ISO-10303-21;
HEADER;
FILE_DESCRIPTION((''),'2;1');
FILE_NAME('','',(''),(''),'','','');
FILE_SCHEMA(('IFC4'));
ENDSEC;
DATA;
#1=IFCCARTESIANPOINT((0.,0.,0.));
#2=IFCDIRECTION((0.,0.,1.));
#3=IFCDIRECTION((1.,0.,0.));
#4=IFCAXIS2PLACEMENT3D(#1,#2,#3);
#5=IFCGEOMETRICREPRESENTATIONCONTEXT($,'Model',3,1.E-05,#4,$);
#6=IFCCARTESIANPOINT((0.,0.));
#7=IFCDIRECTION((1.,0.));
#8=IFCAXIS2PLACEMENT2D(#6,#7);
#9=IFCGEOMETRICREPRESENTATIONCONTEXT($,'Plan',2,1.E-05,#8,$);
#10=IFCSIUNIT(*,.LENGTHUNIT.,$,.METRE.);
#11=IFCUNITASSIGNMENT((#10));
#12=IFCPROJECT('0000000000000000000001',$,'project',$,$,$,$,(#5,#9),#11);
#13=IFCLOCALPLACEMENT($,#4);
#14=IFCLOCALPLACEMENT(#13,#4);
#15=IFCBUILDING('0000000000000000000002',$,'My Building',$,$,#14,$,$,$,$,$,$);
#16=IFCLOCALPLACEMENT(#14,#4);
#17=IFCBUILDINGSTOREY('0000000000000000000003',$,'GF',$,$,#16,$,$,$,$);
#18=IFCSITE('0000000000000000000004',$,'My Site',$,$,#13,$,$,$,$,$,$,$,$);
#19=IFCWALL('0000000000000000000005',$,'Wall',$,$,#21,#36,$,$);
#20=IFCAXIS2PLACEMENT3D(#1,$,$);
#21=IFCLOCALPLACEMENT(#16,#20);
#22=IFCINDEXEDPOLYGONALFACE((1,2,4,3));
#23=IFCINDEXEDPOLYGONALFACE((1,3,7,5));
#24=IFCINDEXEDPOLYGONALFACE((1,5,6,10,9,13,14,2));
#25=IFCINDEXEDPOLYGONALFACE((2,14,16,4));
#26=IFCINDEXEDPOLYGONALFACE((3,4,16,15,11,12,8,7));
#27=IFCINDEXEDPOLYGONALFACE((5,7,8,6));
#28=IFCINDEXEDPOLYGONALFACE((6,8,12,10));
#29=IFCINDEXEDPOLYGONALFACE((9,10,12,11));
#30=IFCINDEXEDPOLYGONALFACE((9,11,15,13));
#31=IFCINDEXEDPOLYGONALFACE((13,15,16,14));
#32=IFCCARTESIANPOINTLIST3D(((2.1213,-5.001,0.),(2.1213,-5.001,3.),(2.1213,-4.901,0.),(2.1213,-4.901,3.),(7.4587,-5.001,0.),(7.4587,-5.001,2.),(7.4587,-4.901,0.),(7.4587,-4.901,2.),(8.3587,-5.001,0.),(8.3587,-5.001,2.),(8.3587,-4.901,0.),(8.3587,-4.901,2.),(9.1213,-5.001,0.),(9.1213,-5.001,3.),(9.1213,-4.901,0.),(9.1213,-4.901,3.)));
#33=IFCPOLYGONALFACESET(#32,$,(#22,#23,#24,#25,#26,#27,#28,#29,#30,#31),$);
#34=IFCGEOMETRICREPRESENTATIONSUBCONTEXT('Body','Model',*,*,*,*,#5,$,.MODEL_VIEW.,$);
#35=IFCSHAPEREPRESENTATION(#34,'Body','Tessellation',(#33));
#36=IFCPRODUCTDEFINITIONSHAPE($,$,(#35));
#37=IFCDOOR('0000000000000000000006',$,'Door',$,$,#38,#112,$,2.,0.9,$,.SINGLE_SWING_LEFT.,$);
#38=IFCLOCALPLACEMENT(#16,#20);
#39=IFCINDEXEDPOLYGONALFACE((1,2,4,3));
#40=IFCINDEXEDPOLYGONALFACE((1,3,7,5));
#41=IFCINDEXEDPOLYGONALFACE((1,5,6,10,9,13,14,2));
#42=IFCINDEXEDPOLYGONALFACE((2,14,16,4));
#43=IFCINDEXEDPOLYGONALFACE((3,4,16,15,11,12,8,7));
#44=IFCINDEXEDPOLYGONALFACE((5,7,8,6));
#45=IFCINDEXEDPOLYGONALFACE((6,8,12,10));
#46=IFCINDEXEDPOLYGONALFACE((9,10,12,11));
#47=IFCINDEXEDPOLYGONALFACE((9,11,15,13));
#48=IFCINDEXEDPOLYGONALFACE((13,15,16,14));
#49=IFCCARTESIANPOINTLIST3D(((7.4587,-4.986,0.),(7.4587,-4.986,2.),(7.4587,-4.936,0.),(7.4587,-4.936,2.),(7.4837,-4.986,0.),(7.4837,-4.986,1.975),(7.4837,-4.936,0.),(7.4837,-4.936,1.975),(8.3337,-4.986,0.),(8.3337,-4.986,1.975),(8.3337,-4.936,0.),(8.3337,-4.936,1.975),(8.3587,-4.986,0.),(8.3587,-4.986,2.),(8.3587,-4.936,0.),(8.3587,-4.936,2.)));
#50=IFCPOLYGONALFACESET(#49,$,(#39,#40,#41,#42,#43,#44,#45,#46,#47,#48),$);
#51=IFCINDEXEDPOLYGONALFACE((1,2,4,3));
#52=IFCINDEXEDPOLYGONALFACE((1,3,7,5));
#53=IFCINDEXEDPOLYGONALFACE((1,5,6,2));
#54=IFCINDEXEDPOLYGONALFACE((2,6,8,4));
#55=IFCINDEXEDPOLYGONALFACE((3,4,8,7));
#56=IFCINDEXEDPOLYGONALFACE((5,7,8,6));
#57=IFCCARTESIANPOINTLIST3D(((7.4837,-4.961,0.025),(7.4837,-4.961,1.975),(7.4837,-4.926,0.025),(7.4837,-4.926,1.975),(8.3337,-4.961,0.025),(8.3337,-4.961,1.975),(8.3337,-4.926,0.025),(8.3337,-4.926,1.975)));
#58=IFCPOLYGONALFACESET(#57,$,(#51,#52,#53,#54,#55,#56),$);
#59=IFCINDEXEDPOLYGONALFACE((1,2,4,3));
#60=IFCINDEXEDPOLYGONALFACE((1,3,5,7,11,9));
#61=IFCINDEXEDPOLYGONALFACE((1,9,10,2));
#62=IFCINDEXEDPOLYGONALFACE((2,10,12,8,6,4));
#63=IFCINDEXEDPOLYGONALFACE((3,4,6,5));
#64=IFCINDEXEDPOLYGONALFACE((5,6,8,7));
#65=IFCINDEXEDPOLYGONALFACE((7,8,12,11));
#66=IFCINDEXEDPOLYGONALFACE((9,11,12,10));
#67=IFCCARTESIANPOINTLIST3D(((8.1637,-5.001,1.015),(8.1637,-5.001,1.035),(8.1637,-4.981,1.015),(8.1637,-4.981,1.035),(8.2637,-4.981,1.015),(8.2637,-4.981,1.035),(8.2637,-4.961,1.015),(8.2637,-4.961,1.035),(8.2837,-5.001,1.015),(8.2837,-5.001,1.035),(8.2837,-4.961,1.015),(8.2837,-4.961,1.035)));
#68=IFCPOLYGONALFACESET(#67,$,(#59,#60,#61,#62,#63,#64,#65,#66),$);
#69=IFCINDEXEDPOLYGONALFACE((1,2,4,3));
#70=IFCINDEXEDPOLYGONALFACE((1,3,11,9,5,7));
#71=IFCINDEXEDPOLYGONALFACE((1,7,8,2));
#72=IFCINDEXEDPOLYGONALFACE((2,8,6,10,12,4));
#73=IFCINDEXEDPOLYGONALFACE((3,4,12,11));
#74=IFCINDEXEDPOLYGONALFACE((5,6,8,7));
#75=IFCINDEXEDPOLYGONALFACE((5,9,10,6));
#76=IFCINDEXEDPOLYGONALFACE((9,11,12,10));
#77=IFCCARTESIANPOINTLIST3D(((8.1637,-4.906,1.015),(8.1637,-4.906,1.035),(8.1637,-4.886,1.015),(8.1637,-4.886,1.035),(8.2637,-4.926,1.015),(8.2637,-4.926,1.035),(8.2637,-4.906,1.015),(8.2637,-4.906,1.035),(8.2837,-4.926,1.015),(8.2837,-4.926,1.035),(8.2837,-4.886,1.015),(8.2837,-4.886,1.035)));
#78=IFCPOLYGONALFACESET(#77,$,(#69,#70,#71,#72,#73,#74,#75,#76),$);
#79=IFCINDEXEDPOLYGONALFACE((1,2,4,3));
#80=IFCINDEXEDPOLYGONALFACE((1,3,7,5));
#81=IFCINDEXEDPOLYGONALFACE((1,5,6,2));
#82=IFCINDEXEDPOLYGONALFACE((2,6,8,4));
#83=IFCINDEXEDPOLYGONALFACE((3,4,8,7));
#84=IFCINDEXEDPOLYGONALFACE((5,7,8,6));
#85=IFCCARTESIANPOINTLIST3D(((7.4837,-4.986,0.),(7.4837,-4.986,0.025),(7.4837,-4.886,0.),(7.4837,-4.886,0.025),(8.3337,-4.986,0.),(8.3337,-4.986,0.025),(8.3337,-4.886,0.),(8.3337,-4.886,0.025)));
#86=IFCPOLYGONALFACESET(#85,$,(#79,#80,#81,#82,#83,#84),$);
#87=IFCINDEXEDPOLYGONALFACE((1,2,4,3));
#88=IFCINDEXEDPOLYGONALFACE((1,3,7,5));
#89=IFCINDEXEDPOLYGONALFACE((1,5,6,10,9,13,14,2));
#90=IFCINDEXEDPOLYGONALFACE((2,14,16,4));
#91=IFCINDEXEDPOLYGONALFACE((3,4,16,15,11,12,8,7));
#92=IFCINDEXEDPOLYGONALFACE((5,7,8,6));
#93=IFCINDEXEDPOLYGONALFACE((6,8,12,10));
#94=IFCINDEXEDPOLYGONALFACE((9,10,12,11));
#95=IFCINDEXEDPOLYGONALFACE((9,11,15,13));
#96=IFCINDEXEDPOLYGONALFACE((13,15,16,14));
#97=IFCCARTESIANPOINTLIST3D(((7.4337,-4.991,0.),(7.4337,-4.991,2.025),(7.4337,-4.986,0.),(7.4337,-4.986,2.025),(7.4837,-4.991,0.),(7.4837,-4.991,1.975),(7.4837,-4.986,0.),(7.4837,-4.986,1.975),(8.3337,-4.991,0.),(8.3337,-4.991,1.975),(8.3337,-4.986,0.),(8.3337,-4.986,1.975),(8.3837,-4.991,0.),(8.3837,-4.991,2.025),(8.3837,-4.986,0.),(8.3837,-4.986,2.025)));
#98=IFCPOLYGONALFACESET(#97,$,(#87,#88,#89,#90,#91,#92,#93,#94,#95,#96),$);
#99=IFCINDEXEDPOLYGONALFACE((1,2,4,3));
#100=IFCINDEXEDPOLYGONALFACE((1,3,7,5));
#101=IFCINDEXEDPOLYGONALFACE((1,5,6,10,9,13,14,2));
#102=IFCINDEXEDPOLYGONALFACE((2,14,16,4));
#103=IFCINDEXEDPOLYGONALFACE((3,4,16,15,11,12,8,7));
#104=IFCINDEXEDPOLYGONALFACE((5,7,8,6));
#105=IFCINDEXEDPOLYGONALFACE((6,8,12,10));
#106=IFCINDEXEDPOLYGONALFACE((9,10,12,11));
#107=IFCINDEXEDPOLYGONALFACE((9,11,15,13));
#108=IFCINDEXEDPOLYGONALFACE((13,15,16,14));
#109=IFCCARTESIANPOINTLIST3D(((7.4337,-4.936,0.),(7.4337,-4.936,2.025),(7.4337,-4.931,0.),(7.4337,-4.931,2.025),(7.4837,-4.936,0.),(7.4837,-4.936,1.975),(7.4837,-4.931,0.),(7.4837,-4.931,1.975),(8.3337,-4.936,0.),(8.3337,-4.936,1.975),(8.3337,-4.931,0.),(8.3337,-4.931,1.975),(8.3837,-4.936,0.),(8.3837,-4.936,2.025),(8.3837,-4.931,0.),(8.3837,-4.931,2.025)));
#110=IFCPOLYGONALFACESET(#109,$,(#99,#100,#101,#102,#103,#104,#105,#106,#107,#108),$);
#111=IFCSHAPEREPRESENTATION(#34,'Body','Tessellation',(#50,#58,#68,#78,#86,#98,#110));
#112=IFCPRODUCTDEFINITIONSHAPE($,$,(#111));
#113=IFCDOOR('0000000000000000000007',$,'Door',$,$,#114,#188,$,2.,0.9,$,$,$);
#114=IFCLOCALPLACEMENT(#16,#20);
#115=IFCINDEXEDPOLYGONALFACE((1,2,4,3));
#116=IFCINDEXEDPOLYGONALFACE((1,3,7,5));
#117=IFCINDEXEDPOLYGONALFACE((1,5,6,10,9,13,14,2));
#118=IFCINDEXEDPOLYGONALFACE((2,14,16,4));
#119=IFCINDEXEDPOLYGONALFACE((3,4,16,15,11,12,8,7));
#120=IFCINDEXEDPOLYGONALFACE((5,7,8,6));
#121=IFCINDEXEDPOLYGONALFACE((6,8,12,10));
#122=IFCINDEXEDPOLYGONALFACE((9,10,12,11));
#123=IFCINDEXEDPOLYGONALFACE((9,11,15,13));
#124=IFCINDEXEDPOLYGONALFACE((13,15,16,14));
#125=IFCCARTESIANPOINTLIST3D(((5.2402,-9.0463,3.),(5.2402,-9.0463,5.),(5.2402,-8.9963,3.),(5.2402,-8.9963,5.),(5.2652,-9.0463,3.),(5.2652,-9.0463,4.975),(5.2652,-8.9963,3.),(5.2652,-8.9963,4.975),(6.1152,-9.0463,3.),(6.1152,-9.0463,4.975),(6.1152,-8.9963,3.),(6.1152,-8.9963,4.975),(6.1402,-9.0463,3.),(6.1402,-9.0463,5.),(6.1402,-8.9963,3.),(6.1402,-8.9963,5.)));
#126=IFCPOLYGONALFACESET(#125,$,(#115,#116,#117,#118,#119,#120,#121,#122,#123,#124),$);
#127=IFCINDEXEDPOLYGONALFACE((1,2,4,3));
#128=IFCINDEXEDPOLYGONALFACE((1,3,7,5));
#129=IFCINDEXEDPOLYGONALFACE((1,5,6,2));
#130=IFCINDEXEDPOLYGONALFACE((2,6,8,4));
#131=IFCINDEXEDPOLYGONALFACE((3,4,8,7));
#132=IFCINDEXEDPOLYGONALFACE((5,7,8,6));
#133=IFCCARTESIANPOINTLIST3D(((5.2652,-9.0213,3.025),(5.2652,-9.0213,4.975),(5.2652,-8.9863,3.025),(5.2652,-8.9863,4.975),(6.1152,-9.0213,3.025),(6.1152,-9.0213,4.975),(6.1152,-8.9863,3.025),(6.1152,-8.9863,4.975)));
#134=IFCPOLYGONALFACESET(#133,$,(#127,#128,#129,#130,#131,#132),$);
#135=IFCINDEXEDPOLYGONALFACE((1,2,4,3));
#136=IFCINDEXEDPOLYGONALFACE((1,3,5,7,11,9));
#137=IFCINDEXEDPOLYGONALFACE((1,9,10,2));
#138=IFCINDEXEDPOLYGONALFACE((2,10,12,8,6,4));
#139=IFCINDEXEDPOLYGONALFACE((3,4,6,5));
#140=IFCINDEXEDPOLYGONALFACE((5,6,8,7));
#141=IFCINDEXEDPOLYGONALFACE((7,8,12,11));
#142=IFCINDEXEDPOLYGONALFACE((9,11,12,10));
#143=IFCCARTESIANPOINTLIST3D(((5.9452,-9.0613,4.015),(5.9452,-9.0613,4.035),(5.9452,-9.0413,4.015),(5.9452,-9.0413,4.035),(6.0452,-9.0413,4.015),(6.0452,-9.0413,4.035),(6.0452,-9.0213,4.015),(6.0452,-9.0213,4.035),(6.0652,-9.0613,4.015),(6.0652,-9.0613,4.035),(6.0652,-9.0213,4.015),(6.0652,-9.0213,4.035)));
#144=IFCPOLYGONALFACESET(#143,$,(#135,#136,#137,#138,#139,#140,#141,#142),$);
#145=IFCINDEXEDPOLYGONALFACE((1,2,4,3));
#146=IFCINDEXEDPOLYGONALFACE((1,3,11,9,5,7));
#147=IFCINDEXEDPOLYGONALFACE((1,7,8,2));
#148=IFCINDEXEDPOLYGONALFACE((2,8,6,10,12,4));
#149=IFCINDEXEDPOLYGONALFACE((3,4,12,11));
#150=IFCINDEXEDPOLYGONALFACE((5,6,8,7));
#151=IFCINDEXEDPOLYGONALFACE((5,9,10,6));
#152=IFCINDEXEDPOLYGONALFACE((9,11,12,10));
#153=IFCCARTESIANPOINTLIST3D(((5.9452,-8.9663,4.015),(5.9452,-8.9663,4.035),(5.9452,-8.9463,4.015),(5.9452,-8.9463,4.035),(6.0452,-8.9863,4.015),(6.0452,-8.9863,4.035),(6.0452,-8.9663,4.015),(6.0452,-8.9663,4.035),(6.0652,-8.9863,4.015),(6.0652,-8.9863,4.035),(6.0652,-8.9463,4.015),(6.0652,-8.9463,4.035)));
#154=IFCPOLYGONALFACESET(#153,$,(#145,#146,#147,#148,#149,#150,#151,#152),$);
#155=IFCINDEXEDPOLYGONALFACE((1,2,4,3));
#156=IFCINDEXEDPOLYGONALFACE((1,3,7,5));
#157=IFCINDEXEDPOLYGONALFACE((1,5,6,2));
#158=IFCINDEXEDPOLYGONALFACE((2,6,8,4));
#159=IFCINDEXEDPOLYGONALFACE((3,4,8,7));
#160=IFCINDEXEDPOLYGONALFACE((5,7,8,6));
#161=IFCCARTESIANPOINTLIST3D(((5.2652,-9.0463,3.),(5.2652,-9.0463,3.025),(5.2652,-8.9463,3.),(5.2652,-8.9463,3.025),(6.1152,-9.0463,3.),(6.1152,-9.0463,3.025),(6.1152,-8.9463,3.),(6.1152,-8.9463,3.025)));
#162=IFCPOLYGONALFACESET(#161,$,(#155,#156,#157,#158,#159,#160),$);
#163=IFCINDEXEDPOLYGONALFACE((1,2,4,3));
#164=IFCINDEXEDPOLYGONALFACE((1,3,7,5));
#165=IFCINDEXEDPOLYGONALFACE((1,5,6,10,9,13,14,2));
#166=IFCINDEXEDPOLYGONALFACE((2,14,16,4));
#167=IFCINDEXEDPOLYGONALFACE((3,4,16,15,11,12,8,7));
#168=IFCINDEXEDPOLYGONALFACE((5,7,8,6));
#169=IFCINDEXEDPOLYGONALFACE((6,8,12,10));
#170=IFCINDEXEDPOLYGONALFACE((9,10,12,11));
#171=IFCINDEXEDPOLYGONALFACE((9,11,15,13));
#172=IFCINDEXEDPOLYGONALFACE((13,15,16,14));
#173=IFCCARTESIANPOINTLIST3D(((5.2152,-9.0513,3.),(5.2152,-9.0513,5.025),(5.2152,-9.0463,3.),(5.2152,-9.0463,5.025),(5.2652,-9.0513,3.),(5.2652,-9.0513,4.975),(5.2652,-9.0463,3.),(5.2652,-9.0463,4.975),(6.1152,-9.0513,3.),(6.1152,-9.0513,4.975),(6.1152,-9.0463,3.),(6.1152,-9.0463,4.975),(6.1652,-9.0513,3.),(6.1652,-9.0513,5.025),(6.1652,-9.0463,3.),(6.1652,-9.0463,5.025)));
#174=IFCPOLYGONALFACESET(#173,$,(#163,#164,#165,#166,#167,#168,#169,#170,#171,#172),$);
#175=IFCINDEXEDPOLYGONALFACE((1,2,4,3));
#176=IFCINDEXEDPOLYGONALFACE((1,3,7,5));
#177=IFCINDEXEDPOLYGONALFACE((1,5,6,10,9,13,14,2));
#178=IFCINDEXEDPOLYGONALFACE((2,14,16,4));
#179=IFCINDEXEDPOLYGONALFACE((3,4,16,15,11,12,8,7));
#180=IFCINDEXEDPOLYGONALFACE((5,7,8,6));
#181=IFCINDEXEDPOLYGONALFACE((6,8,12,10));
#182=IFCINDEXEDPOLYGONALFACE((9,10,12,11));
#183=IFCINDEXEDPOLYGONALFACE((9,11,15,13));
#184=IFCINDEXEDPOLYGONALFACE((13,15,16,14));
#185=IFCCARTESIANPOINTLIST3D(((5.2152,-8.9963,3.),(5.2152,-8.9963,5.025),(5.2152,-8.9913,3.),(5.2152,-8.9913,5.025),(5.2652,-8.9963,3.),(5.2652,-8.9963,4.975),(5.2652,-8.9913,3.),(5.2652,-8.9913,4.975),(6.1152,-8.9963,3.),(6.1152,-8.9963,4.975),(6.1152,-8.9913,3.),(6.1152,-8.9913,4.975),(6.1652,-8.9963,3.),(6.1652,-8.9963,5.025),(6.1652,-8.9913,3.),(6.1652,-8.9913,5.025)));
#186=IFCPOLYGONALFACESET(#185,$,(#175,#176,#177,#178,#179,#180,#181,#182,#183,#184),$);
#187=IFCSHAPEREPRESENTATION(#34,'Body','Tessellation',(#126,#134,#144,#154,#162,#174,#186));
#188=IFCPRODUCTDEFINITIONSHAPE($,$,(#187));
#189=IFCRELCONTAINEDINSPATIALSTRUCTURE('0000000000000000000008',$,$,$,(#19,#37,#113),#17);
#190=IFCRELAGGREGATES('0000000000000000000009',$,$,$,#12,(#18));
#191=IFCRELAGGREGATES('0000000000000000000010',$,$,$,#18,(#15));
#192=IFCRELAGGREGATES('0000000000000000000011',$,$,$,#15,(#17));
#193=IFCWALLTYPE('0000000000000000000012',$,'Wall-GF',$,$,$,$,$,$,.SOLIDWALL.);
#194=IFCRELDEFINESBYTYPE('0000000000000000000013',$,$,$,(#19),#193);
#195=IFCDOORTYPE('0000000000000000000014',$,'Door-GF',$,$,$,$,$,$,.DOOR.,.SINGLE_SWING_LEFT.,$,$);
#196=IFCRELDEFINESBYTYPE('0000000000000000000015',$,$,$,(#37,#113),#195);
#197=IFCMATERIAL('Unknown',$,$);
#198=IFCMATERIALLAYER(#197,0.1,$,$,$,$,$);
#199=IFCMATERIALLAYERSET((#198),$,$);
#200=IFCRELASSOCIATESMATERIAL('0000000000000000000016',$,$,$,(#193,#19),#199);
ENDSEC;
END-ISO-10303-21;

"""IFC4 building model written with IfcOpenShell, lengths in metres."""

from ifc_helpers import new_model, entity, si_unit, frame, origin_with_axes, origin_2d_with_axis, place, context, subcontext, project, spatial, line, indexed_curve, outline, extrude, shape, source, transform, mapped, material, layer, layer_set, layer_usage, type_object, type_shapes, element, fill, save


model = new_model("IFC4")

# Units and contexts
model_context = context("Model", 3, precision=1e-05, world=origin_with_axes())
plan_context = context("Plan", 2, precision=1e-05, world=origin_2d_with_axis())
body_context_1 = subcontext(model_context, "Body", "Model", "MODEL_VIEW")
body_context_2 = subcontext(plan_context, "Body", "Plan", "PLAN_VIEW")
ifc_project = project(units=[si_unit("LENGTHUNIT", "METRE")], contexts=[model_context, plan_context])

# Site, building, storey
site_placement = place(None, origin_with_axes())
site = spatial("IfcSite", under=ifc_project, at=site_placement, Name="My Site")
building_placement = place(site_placement, origin_with_axes())
building = spatial("IfcBuilding", under=site, at=building_placement, Name="My Building")
storey_placement = place(building_placement, origin_with_axes())
storey = spatial("IfcBuildingStorey", under=building, at=storey_placement, Name="GF")

# Shared definitions
ifc_material = material(Name="Unknown")

# Shared definitions
ifc_layer_1 = layer(ifc_material, 0.1)
ifc_layer_set_1 = layer_set([ifc_layer_1])
wall_type = type_object("IfcWallType", Name="Wall-GF", PredefinedType="SOLIDWALL", material=ifc_layer_set_1)

# Shared definitions
shared_shape_1 = source(origin_with_axes(), body_context_1, "Body", "SweptSolid", [
    extrude(outline(indexed_curve([(0.0, 0.0), (0.9, 0.0), (0.9, 2.0), (0.0, 2.0)], segments=[line(1, 2, 3, 4, 1)])), frame((0.0, -0.6, 0.0), z_axis=(0.0, -1.0, 0.0), x_axis=(1.0, 0.0, 0.0)), (0.0, 0.0, -1.0), 1.2),
])
door_type = type_object("IfcDoorType", Name="Door-GF", OperationType="SINGLE_SWING_LEFT", PredefinedType="DOOR")
shared_shape_2 = source(origin_with_axes(), body_context_1, "Body", "SweptSolid", [
    extrude(outline(indexed_curve([(0.0, 0.0), (0.0, 2.0), (0.9, 2.0), (0.9, 0.0), (0.875, 0.0), (0.875, 1.975), (0.025, 1.975), (0.025, 0.0)], segments=[line(1, 2, 3, 4, 5, 6, 7, 8, 1)])), frame((0.0, 0.0, 0.0), z_axis=(0.0, -1.0, 0.0), x_axis=(1.0, 0.0, 0.0)), (0.0, 0.0, -1.0), 0.05),
    extrude(outline(indexed_curve([(0.0, 0.0), (0.85, 0.0), (0.85, 0.035), (0.0, 0.035)], segments=[line(1, 2, 3, 4, 1)])), frame((0.025, 0.025, 0.025), z_axis=(0.0, 0.0, 1.0), x_axis=(1.0, 0.0, 0.0)), (0.0, 0.0, 1.0), 1.95),
    extrude(outline(indexed_curve([(0.0, 0.0), (0.0, -0.04), (-0.12, -0.04), (-0.12, -0.02), (-0.02, -0.02), (-0.02, 0.0)], segments=[line(1, 2, 3, 4, 5, 6, 1)])), frame((0.825, 0.025, 1.015), z_axis=(0.0, 0.0, 1.0), x_axis=(1.0, 0.0, 0.0)), (0.0, 0.0, 1.0), 0.02),
    extrude(outline(indexed_curve([(0.0, 0.0), (0.0, 0.04), (-0.12, 0.04), (-0.12, 0.02), (-0.02, 0.02), (-0.02, 0.0)], segments=[line(1, 2, 3, 4, 5, 6, 1)])), frame((0.825, 0.06, 1.015), z_axis=(0.0, 0.0, 1.0), x_axis=(1.0, 0.0, 0.0)), (0.0, 0.0, 1.0), 0.02),
    extrude(outline(indexed_curve([(0.0, 0.0), (0.85, 0.0), (0.85, 0.1), (0.0, 0.1)], segments=[line(1, 2, 3, 4, 1)])), frame((0.025, 0.0, 0.0), z_axis=(0.0, 0.0, 1.0), x_axis=(1.0, 0.0, 0.0)), (0.0, 0.0, 1.0), 0.025),
    extrude(outline(indexed_curve([(0.0, 0.0), (0.0, 2.025), (0.95, 2.025), (0.95, 0.0), (0.9, 0.0), (0.9, 1.975), (0.05, 1.975), (0.05, 0.0)], segments=[line(1, 2, 3, 4, 5, 6, 7, 8, 1)])), frame((-0.025, -0.005, 0.0), z_axis=(0.0, -1.0, 0.0), x_axis=(1.0, 0.0, 0.0)), (0.0, 0.0, -1.0), 0.005),
    extrude(outline(indexed_curve([(0.0, 0.0), (0.0, 2.025), (0.95, 2.025), (0.95, 0.0), (0.9, 0.0), (0.9, 1.975), (0.05, 1.975), (0.05, 0.0)], segments=[line(1, 2, 3, 4, 5, 6, 7, 8, 1)])), frame((-0.025, 0.05, 0.0), z_axis=(0.0, -1.0, 0.0), x_axis=(1.0, 0.0, 0.0)), (0.0, 0.0, -1.0), 0.005),
])
shared_shape_3 = source(origin_with_axes(), body_context_2, "Body", "Curve2D", [
    entity("IfcIndexedPolyCurve", entity("IfcCartesianPointList2D", [[0.0, 0.0], [0.025, 0.0], [0.025, 0.05], [0.0, 0.05]]), [entity("IfcLineIndex", [1, 2, 3, 4, 1])]),
    entity("IfcIndexedPolyCurve", entity("IfcCartesianPointList2D", [[0.9, 0.0], [0.875, 0.0], [0.875, 0.05], [0.9, 0.05]]), [entity("IfcLineIndex", [1, 2, 3, 4, 1])]),
    entity("IfcIndexedPolyCurve", entity("IfcCartesianPointList2D", [[0.025, 0.05], [0.025, -0.8], [0.06, -0.8]])),
    entity("IfcTrimmedCurve", entity("IfcEllipse", entity("IfcAxis2Placement2D", entity("IfcCartesianPoint", [0.06, 0.05]), entity("IfcDirection", [1.0, 0.0])), 0.815, 0.85), [entity("IfcCartesianPoint", [0.06, -0.8])], [entity("IfcCartesianPoint", [0.06, 0.9])], True, "CARTESIAN"),
    entity("IfcIndexedPolyCurve", entity("IfcCartesianPointList2D", [[0.025, 0.05], [0.06, 0.05], [0.06, 0.9], [0.025, 0.9]]), [entity("IfcLineIndex", [1, 2, 3, 4, 1])]),
])
type_shapes(door_type, [shared_shape_2, shared_shape_3])

# Wall, opening, door
ifc_layer_usage_1 = layer_usage(ifc_layer_set_1, "AXIS2", "POSITIVE", 0.0)
wall_1_placement = place(storey_placement, frame((2.1213, -5.001, 0.0), z_axis=(0.0, 0.0, 1.0), x_axis=(1.0, 0.0, 0.0)))
wall_1 = element("IfcWall", 1, at=wall_1_placement, inside=storey, type_object=wall_type, material=ifc_layer_usage_1, Name="Wall", context=body_context_1, shape_type="SweptSolid", body=[
    extrude(outline(indexed_curve([(0.0, 0.0), (0.0, 0.1), (7.0, 0.1), (7.0, 0.0)], segments=[line(1, 2, 3, 4, 1)])), origin_with_axes(), (0.0, 0.0, 1.0), 3.0),
])
opening_1_placement = place(wall_1_placement, frame((6.2374, 0.1, 0.0), z_axis=(0.0, 0.0, 1.0), x_axis=(-1.0, 0.0, 0.0)))
opening_1 = element("IfcOpeningElement", 2, at=opening_1_placement, cuts=wall_1, PredefinedType="OPENING", context=body_context_1, shape_type="MappedRepresentation", body=[
    mapped(shared_shape_1, transform((0.0, 0.0, 0.0), x_axis=(1.0, 0.0, 0.0), y_axis=(0.0, 1.0, 0.0), z_axis=(0.0, 0.0, 1.0), scale=1.0)),
])
door_1_placement = place(opening_1_placement, frame((0.9, 0.085, 0.0), z_axis=(0.0, 0.0, 1.0), x_axis=(-1.0, 0.0, 0.0)))
door_1 = element("IfcDoor", 3, at=door_1_placement, inside=storey, type_object=door_type, Name="Door", OperationType="SINGLE_SWING_LEFT", OverallHeight=2.0, OverallWidth=0.9, shapes=[
    shape(body_context_1, "Body", "MappedRepresentation", [mapped(shared_shape_2, transform((0.0, 0.0, 0.0), x_axis=(1.0, 0.0, 0.0), y_axis=(0.0, 1.0, 0.0), z_axis=(0.0, 0.0, 1.0), scale=1.0))]),
    shape(body_context_2, "Body", "MappedRepresentation", [mapped(shared_shape_3, transform((0.0, 0.0, 0.0), x_axis=(1.0, 0.0, 0.0), y_axis=(0.0, 1.0, 0.0), z_axis=(0.0, 0.0, 1.0), scale=1.0))]),
])
fill(opening_1, door_1)

# Door
door_2_placement = place(storey_placement, frame((5.2402, -9.0463, 3.0), z_axis=(0.0, 0.0, 1.0), x_axis=(1.0, 0.0, 0.0)))
element("IfcDoor", 4, at=door_2_placement, inside=storey, type_object=door_type, Name="Door", OverallHeight=2.0, OverallWidth=0.9, shapes=[
    shape(body_context_1, "Body", "MappedRepresentation", [mapped(shared_shape_2, transform((0.0, 0.0, 0.0), x_axis=(1.0, 0.0, 0.0), y_axis=(0.0, 1.0, 0.0), z_axis=(0.0, 0.0, 1.0), scale=1.0))]),
    shape(body_context_2, "Body", "MappedRepresentation", [mapped(shared_shape_3, transform((0.0, 0.0, 0.0), x_axis=(1.0, 0.0, 0.0), y_axis=(0.0, 1.0, 0.0), z_axis=(0.0, 0.0, 1.0), scale=1.0))]),
])

save(model, "model.ifc")
